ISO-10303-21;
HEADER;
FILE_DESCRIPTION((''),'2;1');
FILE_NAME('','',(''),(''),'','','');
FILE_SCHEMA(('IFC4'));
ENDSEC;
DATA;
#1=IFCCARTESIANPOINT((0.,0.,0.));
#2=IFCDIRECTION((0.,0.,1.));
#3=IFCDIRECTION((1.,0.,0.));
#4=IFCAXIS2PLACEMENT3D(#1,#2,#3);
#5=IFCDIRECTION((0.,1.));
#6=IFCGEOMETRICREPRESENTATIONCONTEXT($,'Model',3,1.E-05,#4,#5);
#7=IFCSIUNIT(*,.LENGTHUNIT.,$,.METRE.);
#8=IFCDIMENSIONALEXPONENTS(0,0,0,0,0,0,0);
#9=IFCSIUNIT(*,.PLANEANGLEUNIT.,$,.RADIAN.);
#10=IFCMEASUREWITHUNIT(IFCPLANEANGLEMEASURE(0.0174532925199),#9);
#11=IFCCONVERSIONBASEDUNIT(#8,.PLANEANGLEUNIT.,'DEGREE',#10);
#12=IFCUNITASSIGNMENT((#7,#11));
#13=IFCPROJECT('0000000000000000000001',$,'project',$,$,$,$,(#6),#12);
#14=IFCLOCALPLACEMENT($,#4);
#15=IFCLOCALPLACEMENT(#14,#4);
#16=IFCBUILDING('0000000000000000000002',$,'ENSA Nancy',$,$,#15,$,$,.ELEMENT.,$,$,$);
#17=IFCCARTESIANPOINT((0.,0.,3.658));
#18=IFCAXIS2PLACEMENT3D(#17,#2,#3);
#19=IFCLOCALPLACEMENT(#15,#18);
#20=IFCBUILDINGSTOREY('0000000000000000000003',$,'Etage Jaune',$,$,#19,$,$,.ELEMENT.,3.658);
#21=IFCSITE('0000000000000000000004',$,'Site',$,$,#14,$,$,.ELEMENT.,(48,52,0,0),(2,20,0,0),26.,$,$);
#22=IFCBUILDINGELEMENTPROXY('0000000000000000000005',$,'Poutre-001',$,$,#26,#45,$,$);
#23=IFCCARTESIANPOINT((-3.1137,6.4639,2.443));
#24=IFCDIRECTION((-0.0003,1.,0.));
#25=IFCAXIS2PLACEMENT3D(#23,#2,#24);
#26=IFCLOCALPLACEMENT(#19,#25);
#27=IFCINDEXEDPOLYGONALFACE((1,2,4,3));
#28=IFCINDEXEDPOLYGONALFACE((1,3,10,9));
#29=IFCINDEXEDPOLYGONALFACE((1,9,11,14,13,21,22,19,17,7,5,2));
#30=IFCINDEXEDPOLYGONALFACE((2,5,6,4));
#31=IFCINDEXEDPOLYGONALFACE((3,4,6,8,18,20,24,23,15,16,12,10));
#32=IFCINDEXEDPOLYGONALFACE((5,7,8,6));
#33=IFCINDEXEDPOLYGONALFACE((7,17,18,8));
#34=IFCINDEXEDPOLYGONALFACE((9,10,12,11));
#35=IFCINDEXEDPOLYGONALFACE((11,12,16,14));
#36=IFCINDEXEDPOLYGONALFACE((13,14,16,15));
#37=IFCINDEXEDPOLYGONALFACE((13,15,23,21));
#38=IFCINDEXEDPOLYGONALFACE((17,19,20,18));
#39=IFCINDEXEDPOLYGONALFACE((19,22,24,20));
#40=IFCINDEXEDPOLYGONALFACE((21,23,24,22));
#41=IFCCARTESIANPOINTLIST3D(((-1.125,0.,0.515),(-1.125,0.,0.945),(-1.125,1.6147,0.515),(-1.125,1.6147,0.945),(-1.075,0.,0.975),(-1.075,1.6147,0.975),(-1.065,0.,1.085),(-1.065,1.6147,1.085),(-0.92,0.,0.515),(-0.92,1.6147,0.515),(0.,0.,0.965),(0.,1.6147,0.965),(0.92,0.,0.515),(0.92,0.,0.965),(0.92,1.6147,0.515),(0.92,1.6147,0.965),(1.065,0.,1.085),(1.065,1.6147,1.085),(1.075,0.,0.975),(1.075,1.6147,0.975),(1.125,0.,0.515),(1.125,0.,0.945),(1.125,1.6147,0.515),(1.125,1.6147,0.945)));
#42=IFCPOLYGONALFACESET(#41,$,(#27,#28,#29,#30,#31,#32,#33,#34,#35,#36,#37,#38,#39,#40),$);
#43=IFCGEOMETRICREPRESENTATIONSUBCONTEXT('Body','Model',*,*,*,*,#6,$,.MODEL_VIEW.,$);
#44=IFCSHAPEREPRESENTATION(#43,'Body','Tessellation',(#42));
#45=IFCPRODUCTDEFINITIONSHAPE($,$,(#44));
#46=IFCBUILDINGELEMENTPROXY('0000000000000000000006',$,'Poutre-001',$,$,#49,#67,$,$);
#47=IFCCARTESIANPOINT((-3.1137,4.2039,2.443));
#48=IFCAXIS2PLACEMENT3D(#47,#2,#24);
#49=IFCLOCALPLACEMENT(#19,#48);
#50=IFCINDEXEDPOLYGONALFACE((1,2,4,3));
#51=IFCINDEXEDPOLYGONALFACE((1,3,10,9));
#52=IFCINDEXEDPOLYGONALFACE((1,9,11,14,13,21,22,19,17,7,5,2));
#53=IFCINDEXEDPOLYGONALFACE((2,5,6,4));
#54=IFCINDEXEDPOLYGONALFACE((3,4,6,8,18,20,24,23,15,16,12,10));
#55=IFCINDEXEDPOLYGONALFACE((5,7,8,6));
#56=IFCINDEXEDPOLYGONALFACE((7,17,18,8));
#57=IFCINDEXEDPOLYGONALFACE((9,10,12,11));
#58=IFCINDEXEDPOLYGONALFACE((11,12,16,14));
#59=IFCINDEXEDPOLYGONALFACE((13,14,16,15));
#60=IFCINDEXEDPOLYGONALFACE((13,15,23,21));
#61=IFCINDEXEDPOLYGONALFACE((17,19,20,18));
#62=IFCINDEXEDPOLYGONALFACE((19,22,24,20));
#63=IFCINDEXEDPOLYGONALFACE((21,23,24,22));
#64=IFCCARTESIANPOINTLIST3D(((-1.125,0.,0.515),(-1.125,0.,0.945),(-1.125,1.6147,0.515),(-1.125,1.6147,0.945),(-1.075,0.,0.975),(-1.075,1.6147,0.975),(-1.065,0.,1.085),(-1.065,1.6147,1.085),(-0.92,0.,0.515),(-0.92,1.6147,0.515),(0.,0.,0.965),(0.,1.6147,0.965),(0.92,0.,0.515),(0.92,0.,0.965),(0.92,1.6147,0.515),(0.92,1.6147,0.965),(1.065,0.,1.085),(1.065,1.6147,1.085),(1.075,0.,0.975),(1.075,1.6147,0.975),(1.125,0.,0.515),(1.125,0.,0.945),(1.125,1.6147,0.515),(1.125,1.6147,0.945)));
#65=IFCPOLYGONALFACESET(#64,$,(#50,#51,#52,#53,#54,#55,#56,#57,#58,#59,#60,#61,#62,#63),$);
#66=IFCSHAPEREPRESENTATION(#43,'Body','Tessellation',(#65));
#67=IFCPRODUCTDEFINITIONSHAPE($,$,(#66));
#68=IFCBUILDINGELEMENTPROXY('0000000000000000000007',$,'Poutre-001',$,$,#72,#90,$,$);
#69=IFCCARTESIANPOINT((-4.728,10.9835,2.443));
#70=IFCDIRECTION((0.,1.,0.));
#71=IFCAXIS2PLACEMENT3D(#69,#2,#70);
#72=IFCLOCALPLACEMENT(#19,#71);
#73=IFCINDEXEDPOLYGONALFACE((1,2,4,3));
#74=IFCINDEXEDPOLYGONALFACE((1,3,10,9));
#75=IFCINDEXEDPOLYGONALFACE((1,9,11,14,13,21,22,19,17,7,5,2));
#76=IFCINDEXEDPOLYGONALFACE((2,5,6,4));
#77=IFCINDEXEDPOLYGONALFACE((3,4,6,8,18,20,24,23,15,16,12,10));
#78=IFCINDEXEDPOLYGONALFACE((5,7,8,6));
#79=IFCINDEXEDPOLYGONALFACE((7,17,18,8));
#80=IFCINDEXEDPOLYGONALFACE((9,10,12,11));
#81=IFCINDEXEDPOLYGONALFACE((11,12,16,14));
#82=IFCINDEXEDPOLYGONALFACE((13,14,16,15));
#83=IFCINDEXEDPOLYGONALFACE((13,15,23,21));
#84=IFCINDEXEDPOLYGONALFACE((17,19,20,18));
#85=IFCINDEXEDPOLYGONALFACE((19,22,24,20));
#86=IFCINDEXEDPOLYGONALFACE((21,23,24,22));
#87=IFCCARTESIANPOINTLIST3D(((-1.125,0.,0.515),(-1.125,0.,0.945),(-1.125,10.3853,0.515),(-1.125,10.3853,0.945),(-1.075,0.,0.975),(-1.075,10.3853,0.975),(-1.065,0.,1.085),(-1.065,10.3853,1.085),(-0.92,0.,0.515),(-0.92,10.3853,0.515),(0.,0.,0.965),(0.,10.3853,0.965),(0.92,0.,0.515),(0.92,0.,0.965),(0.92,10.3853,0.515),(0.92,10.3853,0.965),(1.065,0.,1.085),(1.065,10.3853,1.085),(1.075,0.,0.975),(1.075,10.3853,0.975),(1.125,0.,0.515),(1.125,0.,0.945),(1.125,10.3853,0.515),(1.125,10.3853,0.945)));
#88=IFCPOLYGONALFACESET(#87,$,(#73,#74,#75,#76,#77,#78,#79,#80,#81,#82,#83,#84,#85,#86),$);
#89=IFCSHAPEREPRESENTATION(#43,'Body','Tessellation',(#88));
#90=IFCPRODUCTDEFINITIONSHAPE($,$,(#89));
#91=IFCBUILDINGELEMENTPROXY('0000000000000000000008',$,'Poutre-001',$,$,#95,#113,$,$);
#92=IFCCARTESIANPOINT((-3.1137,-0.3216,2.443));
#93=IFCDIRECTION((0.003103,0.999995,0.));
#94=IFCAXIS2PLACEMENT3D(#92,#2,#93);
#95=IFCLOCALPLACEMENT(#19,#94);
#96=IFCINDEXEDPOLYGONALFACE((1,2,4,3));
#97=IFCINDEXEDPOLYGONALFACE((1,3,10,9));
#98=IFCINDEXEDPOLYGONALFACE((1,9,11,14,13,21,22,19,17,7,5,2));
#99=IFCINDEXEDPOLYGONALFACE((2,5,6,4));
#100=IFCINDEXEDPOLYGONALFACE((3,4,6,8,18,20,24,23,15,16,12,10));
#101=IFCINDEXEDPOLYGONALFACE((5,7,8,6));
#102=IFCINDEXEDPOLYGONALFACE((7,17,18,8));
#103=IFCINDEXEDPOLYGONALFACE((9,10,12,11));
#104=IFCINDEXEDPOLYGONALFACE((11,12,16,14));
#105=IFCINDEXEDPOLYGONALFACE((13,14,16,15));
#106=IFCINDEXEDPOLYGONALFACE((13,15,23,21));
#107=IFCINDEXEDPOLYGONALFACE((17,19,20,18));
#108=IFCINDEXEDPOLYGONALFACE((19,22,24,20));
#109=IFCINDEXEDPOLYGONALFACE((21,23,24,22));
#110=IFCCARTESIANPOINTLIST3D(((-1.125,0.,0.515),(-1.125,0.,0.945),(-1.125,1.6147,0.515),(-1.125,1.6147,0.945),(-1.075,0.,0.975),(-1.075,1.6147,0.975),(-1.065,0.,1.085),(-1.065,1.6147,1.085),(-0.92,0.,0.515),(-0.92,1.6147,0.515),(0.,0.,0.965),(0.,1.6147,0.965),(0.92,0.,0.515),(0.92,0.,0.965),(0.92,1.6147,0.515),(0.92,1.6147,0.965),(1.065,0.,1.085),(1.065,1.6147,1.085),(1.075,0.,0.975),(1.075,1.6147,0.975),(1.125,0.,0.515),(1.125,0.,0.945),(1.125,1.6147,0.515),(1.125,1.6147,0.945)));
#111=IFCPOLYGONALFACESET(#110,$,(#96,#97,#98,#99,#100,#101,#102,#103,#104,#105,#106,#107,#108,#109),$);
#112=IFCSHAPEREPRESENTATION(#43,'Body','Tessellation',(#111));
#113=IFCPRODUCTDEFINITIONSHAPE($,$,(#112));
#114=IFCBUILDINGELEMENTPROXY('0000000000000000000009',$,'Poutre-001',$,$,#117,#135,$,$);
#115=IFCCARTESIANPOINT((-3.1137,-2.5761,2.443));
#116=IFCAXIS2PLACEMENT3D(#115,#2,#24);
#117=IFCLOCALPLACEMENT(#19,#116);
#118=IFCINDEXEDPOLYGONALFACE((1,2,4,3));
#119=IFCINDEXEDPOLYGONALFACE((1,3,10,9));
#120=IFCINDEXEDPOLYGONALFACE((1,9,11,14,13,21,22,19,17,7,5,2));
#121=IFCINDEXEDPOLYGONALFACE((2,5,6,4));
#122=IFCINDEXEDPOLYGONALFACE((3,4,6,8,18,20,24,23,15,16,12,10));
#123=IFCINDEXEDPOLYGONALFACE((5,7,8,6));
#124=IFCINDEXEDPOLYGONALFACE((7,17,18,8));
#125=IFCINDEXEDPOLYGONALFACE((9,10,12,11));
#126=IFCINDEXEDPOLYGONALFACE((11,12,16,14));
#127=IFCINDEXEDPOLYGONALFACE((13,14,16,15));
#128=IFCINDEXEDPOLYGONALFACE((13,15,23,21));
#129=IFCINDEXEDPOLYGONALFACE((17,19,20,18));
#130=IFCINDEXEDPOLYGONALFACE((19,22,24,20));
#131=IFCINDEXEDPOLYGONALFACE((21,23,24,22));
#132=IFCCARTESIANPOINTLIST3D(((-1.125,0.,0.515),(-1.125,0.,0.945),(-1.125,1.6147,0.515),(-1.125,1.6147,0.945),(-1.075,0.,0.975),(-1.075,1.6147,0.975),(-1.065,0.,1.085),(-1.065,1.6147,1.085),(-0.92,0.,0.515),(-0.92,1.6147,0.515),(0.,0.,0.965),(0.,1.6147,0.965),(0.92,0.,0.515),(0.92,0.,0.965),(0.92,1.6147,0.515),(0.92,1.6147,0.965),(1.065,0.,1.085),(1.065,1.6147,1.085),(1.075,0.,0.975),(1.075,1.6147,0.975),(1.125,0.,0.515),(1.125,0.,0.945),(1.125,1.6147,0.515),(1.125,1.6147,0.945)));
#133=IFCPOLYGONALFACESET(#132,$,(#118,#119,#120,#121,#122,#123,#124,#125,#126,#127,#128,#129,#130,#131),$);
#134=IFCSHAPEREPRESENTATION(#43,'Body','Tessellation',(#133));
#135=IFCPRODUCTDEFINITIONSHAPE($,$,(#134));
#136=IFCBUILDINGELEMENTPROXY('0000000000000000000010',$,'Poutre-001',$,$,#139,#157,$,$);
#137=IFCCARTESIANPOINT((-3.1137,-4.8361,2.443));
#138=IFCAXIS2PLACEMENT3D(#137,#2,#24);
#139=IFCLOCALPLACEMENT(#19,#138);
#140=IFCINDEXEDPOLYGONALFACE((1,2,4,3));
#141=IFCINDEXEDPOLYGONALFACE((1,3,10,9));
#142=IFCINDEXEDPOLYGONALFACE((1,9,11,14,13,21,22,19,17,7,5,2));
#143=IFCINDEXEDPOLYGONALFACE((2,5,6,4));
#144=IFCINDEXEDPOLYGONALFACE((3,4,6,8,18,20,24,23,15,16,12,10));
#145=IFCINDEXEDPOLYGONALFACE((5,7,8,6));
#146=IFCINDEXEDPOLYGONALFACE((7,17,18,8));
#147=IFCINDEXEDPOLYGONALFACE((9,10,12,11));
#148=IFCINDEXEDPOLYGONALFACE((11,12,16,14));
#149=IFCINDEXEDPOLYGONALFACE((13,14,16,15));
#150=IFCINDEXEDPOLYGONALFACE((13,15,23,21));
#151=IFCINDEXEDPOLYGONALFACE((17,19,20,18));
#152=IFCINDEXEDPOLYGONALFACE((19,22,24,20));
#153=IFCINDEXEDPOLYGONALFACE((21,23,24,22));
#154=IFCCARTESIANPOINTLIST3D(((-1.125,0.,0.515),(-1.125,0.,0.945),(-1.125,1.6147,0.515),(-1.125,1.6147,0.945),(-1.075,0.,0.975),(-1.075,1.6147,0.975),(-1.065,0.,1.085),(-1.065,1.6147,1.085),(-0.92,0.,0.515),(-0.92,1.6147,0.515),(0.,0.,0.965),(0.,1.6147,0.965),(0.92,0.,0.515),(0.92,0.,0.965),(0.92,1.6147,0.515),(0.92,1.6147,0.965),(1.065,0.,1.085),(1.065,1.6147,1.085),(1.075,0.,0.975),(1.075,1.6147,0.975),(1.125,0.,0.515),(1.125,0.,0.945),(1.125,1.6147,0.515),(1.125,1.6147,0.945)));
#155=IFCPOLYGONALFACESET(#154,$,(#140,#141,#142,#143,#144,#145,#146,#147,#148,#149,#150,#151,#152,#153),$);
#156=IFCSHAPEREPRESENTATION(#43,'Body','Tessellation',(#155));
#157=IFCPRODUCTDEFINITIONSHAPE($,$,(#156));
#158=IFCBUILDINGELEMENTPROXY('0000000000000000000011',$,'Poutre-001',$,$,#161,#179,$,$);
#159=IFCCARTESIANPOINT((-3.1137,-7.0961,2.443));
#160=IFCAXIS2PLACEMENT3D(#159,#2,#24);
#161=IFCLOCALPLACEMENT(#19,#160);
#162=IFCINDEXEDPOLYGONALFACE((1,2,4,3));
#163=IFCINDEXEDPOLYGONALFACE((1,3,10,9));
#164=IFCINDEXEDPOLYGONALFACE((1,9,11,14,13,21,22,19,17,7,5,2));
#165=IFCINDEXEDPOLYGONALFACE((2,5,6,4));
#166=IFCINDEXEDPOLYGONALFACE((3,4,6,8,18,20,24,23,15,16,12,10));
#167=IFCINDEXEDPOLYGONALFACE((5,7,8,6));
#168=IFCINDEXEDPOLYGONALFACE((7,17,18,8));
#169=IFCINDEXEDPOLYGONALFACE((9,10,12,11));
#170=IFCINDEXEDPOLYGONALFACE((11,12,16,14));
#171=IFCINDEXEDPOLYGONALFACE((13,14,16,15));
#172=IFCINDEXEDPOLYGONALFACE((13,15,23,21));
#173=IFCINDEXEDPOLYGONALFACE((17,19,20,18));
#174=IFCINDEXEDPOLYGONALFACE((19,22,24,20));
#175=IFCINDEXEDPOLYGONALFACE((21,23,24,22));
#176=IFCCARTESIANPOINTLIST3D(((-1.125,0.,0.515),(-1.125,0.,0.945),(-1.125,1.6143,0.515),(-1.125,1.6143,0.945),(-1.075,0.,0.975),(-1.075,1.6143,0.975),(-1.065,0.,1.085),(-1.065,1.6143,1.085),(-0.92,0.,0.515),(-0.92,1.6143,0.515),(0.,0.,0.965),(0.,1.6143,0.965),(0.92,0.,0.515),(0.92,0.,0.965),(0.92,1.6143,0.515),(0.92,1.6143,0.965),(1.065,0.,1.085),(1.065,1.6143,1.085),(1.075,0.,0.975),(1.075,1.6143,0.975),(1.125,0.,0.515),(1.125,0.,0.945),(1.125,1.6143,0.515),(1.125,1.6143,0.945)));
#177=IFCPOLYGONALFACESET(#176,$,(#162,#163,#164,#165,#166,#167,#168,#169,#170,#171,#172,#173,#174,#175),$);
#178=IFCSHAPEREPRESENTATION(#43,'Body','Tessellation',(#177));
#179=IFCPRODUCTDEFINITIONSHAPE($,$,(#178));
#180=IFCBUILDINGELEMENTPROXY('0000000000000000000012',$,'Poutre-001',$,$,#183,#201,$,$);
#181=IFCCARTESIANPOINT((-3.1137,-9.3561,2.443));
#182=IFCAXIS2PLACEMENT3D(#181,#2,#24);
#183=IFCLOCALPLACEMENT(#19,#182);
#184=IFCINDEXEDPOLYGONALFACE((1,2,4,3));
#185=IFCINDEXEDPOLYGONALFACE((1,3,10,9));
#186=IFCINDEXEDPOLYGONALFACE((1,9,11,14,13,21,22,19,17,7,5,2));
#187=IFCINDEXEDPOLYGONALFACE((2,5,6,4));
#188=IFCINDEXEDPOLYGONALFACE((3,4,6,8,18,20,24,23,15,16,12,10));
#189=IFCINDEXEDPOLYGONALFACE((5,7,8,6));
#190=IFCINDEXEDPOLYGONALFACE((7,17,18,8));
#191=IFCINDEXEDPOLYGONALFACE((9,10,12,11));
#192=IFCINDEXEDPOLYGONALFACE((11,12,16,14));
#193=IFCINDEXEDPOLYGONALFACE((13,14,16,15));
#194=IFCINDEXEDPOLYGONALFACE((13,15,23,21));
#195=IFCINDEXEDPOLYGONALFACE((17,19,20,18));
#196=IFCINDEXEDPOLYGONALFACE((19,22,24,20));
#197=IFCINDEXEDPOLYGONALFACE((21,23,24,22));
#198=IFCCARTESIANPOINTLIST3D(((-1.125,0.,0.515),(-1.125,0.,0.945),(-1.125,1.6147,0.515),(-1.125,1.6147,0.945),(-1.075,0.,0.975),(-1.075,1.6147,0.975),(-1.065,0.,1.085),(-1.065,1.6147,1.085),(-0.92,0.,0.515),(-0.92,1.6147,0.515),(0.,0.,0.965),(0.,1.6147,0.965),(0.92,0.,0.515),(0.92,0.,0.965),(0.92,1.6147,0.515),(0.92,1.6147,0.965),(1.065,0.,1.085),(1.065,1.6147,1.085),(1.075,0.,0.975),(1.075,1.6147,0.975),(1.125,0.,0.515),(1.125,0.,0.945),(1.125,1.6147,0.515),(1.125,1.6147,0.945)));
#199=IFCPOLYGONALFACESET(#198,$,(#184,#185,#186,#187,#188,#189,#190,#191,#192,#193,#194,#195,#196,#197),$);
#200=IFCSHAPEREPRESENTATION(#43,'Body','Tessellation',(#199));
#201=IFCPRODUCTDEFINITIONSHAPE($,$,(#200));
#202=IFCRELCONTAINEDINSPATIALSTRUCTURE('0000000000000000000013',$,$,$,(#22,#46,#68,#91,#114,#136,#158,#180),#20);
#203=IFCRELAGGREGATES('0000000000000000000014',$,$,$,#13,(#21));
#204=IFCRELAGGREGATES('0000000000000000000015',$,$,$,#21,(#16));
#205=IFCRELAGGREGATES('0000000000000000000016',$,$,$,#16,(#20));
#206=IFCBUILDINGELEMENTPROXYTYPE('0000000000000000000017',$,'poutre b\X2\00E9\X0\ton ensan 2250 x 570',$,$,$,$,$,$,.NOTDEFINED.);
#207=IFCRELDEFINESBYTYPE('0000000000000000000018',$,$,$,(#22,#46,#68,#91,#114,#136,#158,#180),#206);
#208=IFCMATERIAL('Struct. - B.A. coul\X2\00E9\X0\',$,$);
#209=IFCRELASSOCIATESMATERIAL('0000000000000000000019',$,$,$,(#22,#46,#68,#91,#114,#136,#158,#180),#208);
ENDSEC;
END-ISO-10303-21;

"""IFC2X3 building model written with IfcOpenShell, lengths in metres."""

from ifc_helpers import new_model, entity, si_unit, converted_unit, direction, frame, origin_with_axes, place, context, subcontext, project, spatial, polyline, outline, extrude, material, type_object, element, save


model = new_model("IFC2X3")

# Units and contexts
model_context = context("Model", 3, precision=1e-05, world=origin_with_axes(), true_north=direction((0.0, 1.0)))
body_context = subcontext(model_context, "Body", "Model", "MODEL_VIEW")
ifc_project = project(units=[si_unit("LENGTHUNIT", "METRE"), converted_unit("PLANEANGLEUNIT", "DEGREE", entity("IfcPlaneAngleMeasure", 0.0174532925199), si_unit("PLANEANGLEUNIT", "RADIAN"), dimensions=[0, 0, 0, 0, 0, 0, 0])], contexts=[model_context])

# Site, building, storey
site_placement = place(None, origin_with_axes())
site = spatial("IfcSite", under=ifc_project, at=site_placement, Name="Site", CompositionType="ELEMENT", RefLatitude=(48, 52, 0, 0), RefLongitude=(2, 20, 0, 0), RefElevation=26.0)
building_placement = place(site_placement, origin_with_axes())
building = spatial("IfcBuilding", under=site, at=building_placement, Name="ENSA Nancy", CompositionType="ELEMENT")
storey_placement = place(building_placement, frame((0.0, 0.0, 3.658), z_axis=(0.0, 0.0, 1.0), x_axis=(1.0, 0.0, 0.0)))
storey = spatial("IfcBuildingStorey", under=building, at=storey_placement, Name="Etage Jaune", CompositionType="ELEMENT", Elevation=3.658)

# Building element proxies
ifc_material_1 = material(Name="Struct. - B.A. coulé")
building_element_proxy_type_1 = type_object("IfcBuildingElementProxyType", Name="poutre béton ensan 2250 x 570", PredefinedType="NOTDEFINED")
for number, where, z_axis, x_axis, name in (
    (1, (-3.1137, 6.4639, 2.443), (0.0, 0.0, 1.0), (-0.0003, 1.0, 0.0), "Poutre-001"),
    (2, (-3.1137, 4.2039, 2.443), (0.0, 0.0, 1.0), (-0.0003, 1.0, 0.0), "Poutre-001"),
):
    element("IfcBuildingElementProxy", number, at=place(storey_placement, frame(where, z_axis=z_axis, x_axis=x_axis)), inside=storey, type_object=building_element_proxy_type_1, material=ifc_material_1, Name=name, context=body_context, shape_type="SweptSolid", body=[
        extrude(outline(polyline([(-1.065, 1.085), (-1.075, 0.975), (-1.125, 0.945), (-1.125, 0.515), (-0.92, 0.515), (0.0, 0.965), (0.92, 0.965), (0.92, 0.515), (1.125, 0.515), (1.125, 0.945), (1.075, 0.975), (1.065, 1.085), (-1.065, 1.085)])), frame((0.0, 1.6147, 0.0), z_axis=(0.0, -1.0, 0.0), x_axis=(1.0, 0.0, 0.0)), (0.0, 0.0, 1.0), 1.6147),
    ])
proxy_1_placement = place(storey_placement, frame((-4.728, 10.9835, 2.443), z_axis=(0.0, 0.0, 1.0), x_axis=(0.0, 1.0, 0.0)))
element("IfcBuildingElementProxy", 3, at=proxy_1_placement, inside=storey, type_object=building_element_proxy_type_1, material=ifc_material_1, Name="Poutre-001", context=body_context, shape_type="SweptSolid", body=[
    extrude(outline(polyline([(-1.065, 1.085), (-1.075, 0.975), (-1.125, 0.945), (-1.125, 0.515), (-0.92, 0.515), (0.0, 0.965), (0.92, 0.965), (0.92, 0.515), (1.125, 0.515), (1.125, 0.945), (1.075, 0.975), (1.065, 1.085), (-1.065, 1.085)])), frame((0.0, 10.3853, 0.0), z_axis=(0.0, -1.0, 0.0), x_axis=(1.0, 0.0, 0.0)), (0.0, 0.0, 1.0), 10.3853),
])
proxy_2_placement = place(storey_placement, frame((-3.1137, -0.3216, 2.443), z_axis=(0.0, 0.0, 1.0), x_axis=(0.003103, 0.999995, 0.0)))
element("IfcBuildingElementProxy", 4, at=proxy_2_placement, inside=storey, type_object=building_element_proxy_type_1, material=ifc_material_1, Name="Poutre-001", context=body_context, shape_type="SweptSolid", body=[
    extrude(outline(polyline([(-1.065, 1.085), (-1.075, 0.975), (-1.125, 0.945), (-1.125, 0.515), (-0.92, 0.515), (0.0, 0.965), (0.92, 0.965), (0.92, 0.515), (1.125, 0.515), (1.125, 0.945), (1.075, 0.975), (1.065, 1.085), (-1.065, 1.085)])), frame((0.0, 1.6147, 0.0), z_axis=(0.0, -1.0, 0.0), x_axis=(1.0, 0.0, 0.0)), (0.0, 0.0, 1.0), 1.6147),
])
for number, where, z_axis, x_axis, name in (
    (5, (-3.1137, -2.5761, 2.443), (0.0, 0.0, 1.0), (-0.0003, 1.0, 0.0), "Poutre-001"),
    (6, (-3.1137, -4.8361, 2.443), (0.0, 0.0, 1.0), (-0.0003, 1.0, 0.0), "Poutre-001"),
):
    element("IfcBuildingElementProxy", number, at=place(storey_placement, frame(where, z_axis=z_axis, x_axis=x_axis)), inside=storey, type_object=building_element_proxy_type_1, material=ifc_material_1, Name=name, context=body_context, shape_type="SweptSolid", body=[
        extrude(outline(polyline([(-1.065, 1.085), (-1.075, 0.975), (-1.125, 0.945), (-1.125, 0.515), (-0.92, 0.515), (0.0, 0.965), (0.92, 0.965), (0.92, 0.515), (1.125, 0.515), (1.125, 0.945), (1.075, 0.975), (1.065, 1.085), (-1.065, 1.085)])), frame((0.0, 1.6147, 0.0), z_axis=(0.0, -1.0, 0.0), x_axis=(1.0, 0.0, 0.0)), (0.0, 0.0, 1.0), 1.6147),
    ])
proxy_3_placement = place(storey_placement, frame((-3.1137, -7.0961, 2.443), z_axis=(0.0, 0.0, 1.0), x_axis=(-0.0003, 1.0, 0.0)))
element("IfcBuildingElementProxy", 7, at=proxy_3_placement, inside=storey, type_object=building_element_proxy_type_1, material=ifc_material_1, Name="Poutre-001", context=body_context, shape_type="SweptSolid", body=[
    extrude(outline(polyline([(-1.065, 1.085), (-1.075, 0.975), (-1.125, 0.945), (-1.125, 0.515), (-0.92, 0.515), (0.0, 0.965), (0.92, 0.965), (0.92, 0.515), (1.125, 0.515), (1.125, 0.945), (1.075, 0.975), (1.065, 1.085), (-1.065, 1.085)])), frame((0.0, 1.6143, 0.0), z_axis=(0.0, -1.0, 0.0), x_axis=(1.0, 0.0, 0.0)), (0.0, 0.0, 1.0), 1.6143),
])
for number, where, z_axis, x_axis, name in (
    (8, (-3.1137, -9.3561, 2.443), (0.0, 0.0, 1.0), (-0.0003, 1.0, 0.0), "Poutre-001"),
):
    element("IfcBuildingElementProxy", number, at=place(storey_placement, frame(where, z_axis=z_axis, x_axis=x_axis)), inside=storey, type_object=building_element_proxy_type_1, material=ifc_material_1, Name=name, context=body_context, shape_type="SweptSolid", body=[
        extrude(outline(polyline([(-1.065, 1.085), (-1.075, 0.975), (-1.125, 0.945), (-1.125, 0.515), (-0.92, 0.515), (0.0, 0.965), (0.92, 0.965), (0.92, 0.515), (1.125, 0.515), (1.125, 0.945), (1.075, 0.975), (1.065, 1.085), (-1.065, 1.085)])), frame((0.0, 1.6147, 0.0), z_axis=(0.0, -1.0, 0.0), x_axis=(1.0, 0.0, 0.0)), (0.0, 0.0, 1.0), 1.6147),
    ])

save(model, "model.ifc")
